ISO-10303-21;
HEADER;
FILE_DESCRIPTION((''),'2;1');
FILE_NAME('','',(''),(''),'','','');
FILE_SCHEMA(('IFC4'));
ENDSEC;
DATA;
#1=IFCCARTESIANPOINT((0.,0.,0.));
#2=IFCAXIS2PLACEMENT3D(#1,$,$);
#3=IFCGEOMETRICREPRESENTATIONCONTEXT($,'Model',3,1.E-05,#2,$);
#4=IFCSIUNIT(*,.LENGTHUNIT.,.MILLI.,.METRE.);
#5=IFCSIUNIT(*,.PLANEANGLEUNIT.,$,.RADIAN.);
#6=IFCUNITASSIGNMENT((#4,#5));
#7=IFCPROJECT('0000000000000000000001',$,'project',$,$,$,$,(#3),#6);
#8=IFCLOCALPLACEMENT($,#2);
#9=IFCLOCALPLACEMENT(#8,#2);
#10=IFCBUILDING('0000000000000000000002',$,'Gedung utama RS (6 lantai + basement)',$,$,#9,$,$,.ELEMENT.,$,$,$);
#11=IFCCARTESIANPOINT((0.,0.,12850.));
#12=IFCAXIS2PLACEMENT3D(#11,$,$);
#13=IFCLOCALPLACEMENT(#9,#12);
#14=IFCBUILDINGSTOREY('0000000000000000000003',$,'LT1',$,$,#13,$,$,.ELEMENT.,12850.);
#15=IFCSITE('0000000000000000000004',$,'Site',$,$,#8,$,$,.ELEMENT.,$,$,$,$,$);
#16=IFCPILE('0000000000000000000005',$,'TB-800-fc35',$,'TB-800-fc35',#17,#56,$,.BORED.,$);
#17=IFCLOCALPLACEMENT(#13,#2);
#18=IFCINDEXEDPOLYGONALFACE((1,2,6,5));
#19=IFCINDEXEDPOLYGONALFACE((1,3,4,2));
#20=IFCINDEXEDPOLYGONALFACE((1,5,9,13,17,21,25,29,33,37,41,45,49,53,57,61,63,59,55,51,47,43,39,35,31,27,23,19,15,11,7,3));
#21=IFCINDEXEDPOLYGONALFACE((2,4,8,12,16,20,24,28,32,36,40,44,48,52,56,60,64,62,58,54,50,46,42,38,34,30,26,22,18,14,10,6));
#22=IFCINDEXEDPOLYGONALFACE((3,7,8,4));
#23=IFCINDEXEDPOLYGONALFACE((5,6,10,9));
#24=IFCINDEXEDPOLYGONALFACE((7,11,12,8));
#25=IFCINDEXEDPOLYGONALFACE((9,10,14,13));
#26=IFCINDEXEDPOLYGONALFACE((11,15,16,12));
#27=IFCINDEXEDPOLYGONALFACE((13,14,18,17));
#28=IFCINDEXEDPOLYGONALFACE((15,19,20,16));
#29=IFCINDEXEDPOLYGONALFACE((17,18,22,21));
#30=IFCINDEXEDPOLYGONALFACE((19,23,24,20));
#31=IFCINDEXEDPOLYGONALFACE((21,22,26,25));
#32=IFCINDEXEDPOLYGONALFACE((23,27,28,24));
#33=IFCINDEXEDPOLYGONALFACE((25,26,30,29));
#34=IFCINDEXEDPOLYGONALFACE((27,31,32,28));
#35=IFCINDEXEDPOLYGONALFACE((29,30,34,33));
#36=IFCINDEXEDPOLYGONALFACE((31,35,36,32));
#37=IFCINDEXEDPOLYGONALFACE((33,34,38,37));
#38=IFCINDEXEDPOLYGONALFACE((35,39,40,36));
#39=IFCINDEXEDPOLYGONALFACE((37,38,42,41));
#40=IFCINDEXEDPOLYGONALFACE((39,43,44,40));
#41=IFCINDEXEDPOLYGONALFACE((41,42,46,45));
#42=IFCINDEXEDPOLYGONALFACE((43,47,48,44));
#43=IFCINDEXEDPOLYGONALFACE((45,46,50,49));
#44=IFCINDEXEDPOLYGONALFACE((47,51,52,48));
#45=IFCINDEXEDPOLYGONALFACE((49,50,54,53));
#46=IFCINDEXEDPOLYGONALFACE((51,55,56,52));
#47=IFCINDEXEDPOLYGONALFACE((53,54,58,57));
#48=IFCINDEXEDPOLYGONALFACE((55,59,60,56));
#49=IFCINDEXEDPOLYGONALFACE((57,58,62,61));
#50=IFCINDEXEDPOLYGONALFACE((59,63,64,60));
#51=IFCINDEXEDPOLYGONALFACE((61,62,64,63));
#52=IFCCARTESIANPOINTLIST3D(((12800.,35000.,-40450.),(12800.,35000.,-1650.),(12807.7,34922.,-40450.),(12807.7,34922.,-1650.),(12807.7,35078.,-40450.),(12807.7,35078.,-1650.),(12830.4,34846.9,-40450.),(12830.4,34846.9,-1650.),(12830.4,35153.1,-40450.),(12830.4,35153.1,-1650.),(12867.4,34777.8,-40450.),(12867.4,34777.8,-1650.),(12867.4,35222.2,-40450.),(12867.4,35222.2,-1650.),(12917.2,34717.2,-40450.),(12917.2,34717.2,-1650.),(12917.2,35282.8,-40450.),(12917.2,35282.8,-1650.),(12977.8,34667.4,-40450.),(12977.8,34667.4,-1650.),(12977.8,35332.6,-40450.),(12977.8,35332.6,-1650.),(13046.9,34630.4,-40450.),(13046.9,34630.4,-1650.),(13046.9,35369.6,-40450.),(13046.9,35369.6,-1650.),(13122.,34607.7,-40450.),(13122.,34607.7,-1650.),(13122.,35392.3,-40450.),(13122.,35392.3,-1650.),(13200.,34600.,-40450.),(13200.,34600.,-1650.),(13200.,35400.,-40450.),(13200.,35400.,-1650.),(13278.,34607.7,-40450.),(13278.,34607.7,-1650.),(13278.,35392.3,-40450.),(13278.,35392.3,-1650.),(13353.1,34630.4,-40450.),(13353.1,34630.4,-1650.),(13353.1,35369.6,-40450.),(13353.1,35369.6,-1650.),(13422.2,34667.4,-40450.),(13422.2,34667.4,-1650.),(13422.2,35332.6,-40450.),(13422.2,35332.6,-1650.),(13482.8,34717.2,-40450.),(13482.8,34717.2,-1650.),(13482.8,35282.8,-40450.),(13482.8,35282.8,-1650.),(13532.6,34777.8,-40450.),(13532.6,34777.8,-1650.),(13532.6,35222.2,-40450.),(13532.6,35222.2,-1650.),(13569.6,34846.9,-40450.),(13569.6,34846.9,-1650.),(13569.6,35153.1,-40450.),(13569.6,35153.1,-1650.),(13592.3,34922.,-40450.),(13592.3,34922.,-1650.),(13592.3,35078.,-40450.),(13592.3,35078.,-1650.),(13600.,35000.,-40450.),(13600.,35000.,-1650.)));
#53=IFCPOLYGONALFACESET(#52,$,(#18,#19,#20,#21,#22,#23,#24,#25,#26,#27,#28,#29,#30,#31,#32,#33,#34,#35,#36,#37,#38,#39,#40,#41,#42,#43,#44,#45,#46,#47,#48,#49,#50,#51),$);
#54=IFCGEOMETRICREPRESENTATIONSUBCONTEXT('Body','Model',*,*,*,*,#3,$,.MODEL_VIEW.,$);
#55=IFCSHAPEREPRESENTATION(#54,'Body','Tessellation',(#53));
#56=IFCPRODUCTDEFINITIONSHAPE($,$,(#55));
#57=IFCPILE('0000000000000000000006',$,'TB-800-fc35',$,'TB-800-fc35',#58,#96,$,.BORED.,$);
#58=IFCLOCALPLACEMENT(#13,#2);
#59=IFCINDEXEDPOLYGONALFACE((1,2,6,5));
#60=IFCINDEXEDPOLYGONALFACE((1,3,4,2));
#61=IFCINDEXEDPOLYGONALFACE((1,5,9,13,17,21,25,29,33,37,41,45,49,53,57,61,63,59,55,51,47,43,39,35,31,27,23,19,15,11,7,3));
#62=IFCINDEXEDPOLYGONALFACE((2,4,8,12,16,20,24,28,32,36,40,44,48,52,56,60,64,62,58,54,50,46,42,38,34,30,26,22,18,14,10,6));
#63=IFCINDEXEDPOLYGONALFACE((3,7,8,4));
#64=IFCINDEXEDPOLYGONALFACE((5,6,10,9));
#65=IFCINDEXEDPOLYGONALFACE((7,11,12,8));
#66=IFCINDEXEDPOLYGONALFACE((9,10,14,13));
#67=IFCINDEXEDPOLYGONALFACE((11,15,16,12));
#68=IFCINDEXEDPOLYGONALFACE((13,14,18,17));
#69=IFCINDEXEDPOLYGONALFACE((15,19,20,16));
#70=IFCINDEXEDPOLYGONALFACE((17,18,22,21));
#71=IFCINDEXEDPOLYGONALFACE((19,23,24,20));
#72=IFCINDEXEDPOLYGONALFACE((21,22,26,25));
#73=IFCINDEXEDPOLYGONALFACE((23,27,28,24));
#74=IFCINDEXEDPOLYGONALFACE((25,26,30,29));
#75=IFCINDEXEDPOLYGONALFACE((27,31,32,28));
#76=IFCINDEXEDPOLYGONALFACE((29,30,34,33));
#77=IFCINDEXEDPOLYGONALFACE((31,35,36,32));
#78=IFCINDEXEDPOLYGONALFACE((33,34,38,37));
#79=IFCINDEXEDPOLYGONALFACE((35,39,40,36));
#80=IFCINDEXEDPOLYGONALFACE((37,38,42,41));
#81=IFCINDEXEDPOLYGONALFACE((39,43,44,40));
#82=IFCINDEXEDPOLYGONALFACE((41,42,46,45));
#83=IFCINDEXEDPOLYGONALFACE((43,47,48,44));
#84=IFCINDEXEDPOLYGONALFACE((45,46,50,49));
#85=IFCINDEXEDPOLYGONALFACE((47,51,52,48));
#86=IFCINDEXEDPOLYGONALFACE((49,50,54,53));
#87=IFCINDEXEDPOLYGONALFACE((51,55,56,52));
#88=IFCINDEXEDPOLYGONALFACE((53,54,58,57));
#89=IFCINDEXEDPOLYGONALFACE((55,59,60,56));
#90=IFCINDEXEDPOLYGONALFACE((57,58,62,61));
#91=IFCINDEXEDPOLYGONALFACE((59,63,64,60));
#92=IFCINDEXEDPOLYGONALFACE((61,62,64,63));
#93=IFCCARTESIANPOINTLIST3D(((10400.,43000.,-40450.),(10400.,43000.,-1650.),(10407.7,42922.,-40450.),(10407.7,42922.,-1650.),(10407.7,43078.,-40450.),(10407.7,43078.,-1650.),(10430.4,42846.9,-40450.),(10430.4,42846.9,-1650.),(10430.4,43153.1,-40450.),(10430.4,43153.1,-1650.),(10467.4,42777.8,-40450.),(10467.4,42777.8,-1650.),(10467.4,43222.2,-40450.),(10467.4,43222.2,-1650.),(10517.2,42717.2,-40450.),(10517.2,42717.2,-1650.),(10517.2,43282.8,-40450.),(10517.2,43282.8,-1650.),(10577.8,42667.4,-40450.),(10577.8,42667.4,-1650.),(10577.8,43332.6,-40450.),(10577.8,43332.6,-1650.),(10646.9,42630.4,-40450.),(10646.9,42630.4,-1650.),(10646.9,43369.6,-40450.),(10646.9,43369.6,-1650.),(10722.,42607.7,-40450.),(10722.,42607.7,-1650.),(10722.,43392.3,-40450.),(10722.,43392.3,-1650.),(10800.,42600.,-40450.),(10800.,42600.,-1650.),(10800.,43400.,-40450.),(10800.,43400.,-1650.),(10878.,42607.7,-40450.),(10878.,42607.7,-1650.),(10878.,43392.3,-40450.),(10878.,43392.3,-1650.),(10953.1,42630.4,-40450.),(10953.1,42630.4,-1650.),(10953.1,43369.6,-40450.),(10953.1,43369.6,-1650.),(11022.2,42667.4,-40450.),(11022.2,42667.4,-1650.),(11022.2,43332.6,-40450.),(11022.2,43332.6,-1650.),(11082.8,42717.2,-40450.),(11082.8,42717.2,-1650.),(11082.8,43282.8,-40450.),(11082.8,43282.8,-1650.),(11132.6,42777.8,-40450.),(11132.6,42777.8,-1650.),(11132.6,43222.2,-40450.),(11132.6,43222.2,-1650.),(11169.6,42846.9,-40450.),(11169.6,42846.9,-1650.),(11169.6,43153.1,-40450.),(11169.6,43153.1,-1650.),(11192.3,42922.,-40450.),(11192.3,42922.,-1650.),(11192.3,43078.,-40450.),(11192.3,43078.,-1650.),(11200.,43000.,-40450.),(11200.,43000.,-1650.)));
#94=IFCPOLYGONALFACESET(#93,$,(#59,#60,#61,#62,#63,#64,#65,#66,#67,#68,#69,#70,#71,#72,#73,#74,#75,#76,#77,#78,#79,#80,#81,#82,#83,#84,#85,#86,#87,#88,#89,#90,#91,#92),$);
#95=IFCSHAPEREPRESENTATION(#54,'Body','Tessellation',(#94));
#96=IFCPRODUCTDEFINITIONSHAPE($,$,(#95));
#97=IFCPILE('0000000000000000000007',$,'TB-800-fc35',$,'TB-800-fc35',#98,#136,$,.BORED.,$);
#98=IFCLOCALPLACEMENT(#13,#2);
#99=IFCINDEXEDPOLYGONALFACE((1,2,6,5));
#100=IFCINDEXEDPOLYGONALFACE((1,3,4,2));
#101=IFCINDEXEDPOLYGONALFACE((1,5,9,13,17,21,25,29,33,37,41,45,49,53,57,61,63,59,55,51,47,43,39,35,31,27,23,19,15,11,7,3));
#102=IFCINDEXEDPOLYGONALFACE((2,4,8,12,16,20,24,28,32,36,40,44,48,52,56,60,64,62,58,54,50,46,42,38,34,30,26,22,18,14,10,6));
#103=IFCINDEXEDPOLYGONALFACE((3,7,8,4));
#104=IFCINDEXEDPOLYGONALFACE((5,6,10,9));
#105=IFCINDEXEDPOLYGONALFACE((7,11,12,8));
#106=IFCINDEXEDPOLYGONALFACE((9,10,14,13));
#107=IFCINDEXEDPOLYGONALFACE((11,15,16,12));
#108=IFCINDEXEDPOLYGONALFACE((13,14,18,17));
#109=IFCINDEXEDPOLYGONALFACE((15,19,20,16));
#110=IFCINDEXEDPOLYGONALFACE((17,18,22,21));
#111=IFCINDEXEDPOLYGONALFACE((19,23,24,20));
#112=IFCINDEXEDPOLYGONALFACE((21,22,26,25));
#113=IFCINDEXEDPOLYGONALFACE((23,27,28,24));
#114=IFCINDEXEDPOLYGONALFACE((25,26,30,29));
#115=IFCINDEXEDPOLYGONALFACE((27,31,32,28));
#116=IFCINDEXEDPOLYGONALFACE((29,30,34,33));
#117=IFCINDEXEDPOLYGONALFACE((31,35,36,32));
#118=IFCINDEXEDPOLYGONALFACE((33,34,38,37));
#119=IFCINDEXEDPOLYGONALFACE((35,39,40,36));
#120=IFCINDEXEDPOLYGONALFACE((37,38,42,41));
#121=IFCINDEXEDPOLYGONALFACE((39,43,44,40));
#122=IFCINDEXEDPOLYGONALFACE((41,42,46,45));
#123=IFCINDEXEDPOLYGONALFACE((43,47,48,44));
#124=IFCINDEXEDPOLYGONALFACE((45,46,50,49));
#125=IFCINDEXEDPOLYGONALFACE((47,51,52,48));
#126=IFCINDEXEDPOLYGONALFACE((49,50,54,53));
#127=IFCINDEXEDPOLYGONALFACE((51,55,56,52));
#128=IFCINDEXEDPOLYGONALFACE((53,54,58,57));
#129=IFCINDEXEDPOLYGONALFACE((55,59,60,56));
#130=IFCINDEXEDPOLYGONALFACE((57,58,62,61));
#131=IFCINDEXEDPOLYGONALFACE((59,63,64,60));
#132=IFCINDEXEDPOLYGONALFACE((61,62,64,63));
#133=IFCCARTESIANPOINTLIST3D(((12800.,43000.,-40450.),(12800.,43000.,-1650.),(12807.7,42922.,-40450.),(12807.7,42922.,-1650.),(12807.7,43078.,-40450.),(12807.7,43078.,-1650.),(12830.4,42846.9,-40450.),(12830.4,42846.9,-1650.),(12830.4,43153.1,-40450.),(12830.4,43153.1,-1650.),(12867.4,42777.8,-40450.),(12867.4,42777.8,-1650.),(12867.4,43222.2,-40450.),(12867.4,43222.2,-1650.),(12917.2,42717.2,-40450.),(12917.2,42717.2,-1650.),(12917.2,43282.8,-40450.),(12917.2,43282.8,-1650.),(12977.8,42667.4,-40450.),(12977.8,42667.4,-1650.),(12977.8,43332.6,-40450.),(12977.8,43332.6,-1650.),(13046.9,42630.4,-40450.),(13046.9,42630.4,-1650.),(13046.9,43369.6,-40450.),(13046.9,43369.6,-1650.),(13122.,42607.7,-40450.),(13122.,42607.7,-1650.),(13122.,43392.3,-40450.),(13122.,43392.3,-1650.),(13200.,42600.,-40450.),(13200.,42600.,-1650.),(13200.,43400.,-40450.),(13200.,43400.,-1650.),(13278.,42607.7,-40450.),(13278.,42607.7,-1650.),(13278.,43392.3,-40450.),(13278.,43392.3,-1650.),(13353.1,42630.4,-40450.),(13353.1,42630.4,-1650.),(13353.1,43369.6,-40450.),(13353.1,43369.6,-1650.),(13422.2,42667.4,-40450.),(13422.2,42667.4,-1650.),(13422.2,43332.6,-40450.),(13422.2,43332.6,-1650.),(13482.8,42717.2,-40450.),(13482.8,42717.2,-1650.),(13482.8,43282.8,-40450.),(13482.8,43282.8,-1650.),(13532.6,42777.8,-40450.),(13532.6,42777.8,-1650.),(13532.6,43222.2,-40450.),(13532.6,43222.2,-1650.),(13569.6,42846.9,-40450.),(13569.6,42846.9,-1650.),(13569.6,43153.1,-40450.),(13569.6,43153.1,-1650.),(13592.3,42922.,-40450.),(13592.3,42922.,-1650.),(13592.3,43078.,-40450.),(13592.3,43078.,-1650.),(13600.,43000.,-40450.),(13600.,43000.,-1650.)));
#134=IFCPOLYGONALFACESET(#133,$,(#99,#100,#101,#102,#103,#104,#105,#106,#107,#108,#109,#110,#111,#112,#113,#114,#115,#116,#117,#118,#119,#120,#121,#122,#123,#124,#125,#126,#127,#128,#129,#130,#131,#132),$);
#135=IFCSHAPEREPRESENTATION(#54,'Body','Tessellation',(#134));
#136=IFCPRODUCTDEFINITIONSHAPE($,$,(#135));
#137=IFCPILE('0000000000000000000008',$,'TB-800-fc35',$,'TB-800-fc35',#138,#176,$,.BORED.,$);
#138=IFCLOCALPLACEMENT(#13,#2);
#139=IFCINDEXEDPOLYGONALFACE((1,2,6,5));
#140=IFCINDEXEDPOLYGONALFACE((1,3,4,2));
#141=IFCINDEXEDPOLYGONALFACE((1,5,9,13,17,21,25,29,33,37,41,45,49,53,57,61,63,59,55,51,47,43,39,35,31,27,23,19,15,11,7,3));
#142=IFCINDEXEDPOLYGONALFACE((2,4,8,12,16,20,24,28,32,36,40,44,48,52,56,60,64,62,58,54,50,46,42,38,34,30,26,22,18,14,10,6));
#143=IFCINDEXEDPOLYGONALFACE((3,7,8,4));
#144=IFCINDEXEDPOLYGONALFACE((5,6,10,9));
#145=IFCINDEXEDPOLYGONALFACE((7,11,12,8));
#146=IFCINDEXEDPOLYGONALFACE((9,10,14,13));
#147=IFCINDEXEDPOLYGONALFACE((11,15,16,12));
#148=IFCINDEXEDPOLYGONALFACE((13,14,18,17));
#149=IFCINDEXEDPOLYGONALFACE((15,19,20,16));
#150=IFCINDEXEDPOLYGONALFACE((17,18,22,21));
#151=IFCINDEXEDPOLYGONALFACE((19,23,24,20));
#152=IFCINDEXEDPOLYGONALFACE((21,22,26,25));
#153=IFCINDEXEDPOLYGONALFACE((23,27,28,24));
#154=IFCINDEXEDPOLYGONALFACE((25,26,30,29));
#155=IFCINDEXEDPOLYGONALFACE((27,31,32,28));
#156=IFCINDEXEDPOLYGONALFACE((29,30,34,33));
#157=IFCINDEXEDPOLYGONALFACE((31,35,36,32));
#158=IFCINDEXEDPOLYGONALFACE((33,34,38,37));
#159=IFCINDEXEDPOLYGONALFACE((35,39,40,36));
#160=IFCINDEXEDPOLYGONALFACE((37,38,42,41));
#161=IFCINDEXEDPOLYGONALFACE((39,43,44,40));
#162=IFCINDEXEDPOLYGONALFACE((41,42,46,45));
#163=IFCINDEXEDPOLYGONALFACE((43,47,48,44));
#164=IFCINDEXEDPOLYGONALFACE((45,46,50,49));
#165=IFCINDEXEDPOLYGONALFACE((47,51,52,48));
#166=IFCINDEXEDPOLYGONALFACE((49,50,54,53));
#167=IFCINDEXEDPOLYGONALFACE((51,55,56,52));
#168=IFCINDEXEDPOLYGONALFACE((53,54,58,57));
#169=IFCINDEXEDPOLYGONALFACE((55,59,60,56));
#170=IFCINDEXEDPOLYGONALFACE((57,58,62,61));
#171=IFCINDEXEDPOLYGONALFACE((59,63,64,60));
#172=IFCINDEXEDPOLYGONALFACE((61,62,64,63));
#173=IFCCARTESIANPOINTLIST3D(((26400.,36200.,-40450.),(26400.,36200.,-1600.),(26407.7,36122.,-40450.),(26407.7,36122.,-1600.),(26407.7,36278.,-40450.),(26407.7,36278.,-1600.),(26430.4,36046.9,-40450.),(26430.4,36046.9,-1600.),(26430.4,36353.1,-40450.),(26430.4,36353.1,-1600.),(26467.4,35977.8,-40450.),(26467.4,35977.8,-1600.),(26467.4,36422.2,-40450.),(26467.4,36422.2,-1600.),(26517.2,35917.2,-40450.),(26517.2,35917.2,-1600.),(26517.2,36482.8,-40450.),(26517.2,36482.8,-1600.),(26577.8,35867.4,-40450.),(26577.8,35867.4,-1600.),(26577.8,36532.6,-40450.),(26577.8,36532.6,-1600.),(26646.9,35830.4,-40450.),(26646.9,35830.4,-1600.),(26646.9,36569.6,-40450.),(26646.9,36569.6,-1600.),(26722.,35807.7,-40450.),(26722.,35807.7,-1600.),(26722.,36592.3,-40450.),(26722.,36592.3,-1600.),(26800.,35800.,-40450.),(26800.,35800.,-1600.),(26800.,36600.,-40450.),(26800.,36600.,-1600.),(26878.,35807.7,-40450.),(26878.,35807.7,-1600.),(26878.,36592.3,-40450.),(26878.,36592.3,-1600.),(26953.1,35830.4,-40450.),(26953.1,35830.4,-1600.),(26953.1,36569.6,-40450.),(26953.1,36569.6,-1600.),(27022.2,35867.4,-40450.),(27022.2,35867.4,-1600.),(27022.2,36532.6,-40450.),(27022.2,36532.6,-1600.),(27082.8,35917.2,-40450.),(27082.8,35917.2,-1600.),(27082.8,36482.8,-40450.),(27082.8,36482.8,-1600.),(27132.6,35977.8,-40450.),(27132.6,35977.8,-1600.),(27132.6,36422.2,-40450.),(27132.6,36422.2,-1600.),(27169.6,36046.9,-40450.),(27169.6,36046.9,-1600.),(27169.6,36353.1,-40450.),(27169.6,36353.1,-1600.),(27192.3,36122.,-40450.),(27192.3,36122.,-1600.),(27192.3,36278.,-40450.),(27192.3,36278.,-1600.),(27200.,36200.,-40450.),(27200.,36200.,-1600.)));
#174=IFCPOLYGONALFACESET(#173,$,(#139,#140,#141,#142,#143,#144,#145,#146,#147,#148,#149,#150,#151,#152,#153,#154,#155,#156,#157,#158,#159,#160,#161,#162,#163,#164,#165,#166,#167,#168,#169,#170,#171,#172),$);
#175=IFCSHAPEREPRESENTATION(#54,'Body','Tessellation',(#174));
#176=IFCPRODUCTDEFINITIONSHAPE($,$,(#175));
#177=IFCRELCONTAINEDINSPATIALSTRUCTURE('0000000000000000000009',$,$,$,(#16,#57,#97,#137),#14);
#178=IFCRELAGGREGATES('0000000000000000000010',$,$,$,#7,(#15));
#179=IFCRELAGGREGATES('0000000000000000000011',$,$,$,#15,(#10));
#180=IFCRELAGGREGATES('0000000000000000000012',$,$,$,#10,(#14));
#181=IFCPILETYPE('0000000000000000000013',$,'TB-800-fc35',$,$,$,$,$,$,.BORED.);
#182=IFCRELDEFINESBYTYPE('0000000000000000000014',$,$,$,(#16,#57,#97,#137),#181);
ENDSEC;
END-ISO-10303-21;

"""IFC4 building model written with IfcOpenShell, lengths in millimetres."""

from ifc_helpers import new_model, si_unit, frame, origin, origin_2d, place, context, subcontext, project, spatial, circle, extrude, material_profile, profile_set, profile_usage, type_object, element, save


model = new_model("IFC4")

# Units and contexts
model_context = context("Model", 3, precision=1e-05, world=origin())
body_context = subcontext(model_context, "Body", "Model", "MODEL_VIEW")
ifc_project = project(units=[si_unit("LENGTHUNIT", "METRE", prefix="MILLI"), si_unit("PLANEANGLEUNIT", "RADIAN")], contexts=[model_context])

# Site, building, storey
site_placement = place(None, origin())
site = spatial("IfcSite", under=ifc_project, at=site_placement, Name="Site", CompositionType="ELEMENT")
building_placement = place(site_placement, origin())
building = spatial("IfcBuilding", under=site, at=building_placement, Name="Gedung utama RS (6 lantai + basement)", CompositionType="ELEMENT")
storey_placement = place(building_placement, frame((0.0, 0.0, 12850.0)))
storey = spatial("IfcBuildingStorey", under=building, at=storey_placement, Name="LT1", CompositionType="ELEMENT", Elevation=12850.0)

# Piles
ifc_material_profile_1 = material_profile(None, circle(Radius=400.0, at=origin_2d()), Name="TB-800-fc35")
ifc_profile_set_1 = profile_set([ifc_material_profile_1], Name="TB-800-fc35")
ifc_profile_usage_1 = profile_usage(ifc_profile_set_1, cardinal=5)
pile_type = type_object("IfcPileType", Name="TB-800-fc35", PredefinedType="BORED", material=ifc_profile_set_1)
for number, where, z_axis, x_axis, name in (
    (1, (13200.0, 35000.0, -40450.0), (0.0, 0.0, 1.0), (1.0, 0.0, 0.0), "TB-800-fc35"),
    (2, (10800.0, 43000.0, -40450.0), (0.0, 0.0, 1.0), (1.0, 0.0, 0.0), "TB-800-fc35"),
    (3, (13200.0, 43000.0, -40450.0), (0.0, 0.0, 1.0), (1.0, 0.0, 0.0), "TB-800-fc35"),
):
    element("IfcPile", number, at=place(storey_placement, frame(where, z_axis=z_axis, x_axis=x_axis)), inside=storey, type_object=pile_type, material=ifc_profile_usage_1, Name=name, ObjectType="TB-800-fc35", PredefinedType="BORED", context=body_context, shape_type="SweptSolid", body=[
        extrude(circle(Radius=400.0, at=origin_2d()), origin(), (0.0, 0.0, 1.0), 38800.0),
    ])
pile_placement = place(storey_placement, frame((26800.0, 36200.0, -40450.0), z_axis=(0.0, 0.0, 1.0), x_axis=(1.0, 0.0, 0.0)))
element("IfcPile", 4, at=pile_placement, inside=storey, type_object=pile_type, material=ifc_profile_usage_1, Name="TB-800-fc35", ObjectType="TB-800-fc35", PredefinedType="BORED", context=body_context, shape_type="SweptSolid", body=[
    extrude(circle(Radius=400.0, at=origin_2d()), origin(), (0.0, 0.0, 1.0), 38850.0),
])

save(model, "model.ifc")
